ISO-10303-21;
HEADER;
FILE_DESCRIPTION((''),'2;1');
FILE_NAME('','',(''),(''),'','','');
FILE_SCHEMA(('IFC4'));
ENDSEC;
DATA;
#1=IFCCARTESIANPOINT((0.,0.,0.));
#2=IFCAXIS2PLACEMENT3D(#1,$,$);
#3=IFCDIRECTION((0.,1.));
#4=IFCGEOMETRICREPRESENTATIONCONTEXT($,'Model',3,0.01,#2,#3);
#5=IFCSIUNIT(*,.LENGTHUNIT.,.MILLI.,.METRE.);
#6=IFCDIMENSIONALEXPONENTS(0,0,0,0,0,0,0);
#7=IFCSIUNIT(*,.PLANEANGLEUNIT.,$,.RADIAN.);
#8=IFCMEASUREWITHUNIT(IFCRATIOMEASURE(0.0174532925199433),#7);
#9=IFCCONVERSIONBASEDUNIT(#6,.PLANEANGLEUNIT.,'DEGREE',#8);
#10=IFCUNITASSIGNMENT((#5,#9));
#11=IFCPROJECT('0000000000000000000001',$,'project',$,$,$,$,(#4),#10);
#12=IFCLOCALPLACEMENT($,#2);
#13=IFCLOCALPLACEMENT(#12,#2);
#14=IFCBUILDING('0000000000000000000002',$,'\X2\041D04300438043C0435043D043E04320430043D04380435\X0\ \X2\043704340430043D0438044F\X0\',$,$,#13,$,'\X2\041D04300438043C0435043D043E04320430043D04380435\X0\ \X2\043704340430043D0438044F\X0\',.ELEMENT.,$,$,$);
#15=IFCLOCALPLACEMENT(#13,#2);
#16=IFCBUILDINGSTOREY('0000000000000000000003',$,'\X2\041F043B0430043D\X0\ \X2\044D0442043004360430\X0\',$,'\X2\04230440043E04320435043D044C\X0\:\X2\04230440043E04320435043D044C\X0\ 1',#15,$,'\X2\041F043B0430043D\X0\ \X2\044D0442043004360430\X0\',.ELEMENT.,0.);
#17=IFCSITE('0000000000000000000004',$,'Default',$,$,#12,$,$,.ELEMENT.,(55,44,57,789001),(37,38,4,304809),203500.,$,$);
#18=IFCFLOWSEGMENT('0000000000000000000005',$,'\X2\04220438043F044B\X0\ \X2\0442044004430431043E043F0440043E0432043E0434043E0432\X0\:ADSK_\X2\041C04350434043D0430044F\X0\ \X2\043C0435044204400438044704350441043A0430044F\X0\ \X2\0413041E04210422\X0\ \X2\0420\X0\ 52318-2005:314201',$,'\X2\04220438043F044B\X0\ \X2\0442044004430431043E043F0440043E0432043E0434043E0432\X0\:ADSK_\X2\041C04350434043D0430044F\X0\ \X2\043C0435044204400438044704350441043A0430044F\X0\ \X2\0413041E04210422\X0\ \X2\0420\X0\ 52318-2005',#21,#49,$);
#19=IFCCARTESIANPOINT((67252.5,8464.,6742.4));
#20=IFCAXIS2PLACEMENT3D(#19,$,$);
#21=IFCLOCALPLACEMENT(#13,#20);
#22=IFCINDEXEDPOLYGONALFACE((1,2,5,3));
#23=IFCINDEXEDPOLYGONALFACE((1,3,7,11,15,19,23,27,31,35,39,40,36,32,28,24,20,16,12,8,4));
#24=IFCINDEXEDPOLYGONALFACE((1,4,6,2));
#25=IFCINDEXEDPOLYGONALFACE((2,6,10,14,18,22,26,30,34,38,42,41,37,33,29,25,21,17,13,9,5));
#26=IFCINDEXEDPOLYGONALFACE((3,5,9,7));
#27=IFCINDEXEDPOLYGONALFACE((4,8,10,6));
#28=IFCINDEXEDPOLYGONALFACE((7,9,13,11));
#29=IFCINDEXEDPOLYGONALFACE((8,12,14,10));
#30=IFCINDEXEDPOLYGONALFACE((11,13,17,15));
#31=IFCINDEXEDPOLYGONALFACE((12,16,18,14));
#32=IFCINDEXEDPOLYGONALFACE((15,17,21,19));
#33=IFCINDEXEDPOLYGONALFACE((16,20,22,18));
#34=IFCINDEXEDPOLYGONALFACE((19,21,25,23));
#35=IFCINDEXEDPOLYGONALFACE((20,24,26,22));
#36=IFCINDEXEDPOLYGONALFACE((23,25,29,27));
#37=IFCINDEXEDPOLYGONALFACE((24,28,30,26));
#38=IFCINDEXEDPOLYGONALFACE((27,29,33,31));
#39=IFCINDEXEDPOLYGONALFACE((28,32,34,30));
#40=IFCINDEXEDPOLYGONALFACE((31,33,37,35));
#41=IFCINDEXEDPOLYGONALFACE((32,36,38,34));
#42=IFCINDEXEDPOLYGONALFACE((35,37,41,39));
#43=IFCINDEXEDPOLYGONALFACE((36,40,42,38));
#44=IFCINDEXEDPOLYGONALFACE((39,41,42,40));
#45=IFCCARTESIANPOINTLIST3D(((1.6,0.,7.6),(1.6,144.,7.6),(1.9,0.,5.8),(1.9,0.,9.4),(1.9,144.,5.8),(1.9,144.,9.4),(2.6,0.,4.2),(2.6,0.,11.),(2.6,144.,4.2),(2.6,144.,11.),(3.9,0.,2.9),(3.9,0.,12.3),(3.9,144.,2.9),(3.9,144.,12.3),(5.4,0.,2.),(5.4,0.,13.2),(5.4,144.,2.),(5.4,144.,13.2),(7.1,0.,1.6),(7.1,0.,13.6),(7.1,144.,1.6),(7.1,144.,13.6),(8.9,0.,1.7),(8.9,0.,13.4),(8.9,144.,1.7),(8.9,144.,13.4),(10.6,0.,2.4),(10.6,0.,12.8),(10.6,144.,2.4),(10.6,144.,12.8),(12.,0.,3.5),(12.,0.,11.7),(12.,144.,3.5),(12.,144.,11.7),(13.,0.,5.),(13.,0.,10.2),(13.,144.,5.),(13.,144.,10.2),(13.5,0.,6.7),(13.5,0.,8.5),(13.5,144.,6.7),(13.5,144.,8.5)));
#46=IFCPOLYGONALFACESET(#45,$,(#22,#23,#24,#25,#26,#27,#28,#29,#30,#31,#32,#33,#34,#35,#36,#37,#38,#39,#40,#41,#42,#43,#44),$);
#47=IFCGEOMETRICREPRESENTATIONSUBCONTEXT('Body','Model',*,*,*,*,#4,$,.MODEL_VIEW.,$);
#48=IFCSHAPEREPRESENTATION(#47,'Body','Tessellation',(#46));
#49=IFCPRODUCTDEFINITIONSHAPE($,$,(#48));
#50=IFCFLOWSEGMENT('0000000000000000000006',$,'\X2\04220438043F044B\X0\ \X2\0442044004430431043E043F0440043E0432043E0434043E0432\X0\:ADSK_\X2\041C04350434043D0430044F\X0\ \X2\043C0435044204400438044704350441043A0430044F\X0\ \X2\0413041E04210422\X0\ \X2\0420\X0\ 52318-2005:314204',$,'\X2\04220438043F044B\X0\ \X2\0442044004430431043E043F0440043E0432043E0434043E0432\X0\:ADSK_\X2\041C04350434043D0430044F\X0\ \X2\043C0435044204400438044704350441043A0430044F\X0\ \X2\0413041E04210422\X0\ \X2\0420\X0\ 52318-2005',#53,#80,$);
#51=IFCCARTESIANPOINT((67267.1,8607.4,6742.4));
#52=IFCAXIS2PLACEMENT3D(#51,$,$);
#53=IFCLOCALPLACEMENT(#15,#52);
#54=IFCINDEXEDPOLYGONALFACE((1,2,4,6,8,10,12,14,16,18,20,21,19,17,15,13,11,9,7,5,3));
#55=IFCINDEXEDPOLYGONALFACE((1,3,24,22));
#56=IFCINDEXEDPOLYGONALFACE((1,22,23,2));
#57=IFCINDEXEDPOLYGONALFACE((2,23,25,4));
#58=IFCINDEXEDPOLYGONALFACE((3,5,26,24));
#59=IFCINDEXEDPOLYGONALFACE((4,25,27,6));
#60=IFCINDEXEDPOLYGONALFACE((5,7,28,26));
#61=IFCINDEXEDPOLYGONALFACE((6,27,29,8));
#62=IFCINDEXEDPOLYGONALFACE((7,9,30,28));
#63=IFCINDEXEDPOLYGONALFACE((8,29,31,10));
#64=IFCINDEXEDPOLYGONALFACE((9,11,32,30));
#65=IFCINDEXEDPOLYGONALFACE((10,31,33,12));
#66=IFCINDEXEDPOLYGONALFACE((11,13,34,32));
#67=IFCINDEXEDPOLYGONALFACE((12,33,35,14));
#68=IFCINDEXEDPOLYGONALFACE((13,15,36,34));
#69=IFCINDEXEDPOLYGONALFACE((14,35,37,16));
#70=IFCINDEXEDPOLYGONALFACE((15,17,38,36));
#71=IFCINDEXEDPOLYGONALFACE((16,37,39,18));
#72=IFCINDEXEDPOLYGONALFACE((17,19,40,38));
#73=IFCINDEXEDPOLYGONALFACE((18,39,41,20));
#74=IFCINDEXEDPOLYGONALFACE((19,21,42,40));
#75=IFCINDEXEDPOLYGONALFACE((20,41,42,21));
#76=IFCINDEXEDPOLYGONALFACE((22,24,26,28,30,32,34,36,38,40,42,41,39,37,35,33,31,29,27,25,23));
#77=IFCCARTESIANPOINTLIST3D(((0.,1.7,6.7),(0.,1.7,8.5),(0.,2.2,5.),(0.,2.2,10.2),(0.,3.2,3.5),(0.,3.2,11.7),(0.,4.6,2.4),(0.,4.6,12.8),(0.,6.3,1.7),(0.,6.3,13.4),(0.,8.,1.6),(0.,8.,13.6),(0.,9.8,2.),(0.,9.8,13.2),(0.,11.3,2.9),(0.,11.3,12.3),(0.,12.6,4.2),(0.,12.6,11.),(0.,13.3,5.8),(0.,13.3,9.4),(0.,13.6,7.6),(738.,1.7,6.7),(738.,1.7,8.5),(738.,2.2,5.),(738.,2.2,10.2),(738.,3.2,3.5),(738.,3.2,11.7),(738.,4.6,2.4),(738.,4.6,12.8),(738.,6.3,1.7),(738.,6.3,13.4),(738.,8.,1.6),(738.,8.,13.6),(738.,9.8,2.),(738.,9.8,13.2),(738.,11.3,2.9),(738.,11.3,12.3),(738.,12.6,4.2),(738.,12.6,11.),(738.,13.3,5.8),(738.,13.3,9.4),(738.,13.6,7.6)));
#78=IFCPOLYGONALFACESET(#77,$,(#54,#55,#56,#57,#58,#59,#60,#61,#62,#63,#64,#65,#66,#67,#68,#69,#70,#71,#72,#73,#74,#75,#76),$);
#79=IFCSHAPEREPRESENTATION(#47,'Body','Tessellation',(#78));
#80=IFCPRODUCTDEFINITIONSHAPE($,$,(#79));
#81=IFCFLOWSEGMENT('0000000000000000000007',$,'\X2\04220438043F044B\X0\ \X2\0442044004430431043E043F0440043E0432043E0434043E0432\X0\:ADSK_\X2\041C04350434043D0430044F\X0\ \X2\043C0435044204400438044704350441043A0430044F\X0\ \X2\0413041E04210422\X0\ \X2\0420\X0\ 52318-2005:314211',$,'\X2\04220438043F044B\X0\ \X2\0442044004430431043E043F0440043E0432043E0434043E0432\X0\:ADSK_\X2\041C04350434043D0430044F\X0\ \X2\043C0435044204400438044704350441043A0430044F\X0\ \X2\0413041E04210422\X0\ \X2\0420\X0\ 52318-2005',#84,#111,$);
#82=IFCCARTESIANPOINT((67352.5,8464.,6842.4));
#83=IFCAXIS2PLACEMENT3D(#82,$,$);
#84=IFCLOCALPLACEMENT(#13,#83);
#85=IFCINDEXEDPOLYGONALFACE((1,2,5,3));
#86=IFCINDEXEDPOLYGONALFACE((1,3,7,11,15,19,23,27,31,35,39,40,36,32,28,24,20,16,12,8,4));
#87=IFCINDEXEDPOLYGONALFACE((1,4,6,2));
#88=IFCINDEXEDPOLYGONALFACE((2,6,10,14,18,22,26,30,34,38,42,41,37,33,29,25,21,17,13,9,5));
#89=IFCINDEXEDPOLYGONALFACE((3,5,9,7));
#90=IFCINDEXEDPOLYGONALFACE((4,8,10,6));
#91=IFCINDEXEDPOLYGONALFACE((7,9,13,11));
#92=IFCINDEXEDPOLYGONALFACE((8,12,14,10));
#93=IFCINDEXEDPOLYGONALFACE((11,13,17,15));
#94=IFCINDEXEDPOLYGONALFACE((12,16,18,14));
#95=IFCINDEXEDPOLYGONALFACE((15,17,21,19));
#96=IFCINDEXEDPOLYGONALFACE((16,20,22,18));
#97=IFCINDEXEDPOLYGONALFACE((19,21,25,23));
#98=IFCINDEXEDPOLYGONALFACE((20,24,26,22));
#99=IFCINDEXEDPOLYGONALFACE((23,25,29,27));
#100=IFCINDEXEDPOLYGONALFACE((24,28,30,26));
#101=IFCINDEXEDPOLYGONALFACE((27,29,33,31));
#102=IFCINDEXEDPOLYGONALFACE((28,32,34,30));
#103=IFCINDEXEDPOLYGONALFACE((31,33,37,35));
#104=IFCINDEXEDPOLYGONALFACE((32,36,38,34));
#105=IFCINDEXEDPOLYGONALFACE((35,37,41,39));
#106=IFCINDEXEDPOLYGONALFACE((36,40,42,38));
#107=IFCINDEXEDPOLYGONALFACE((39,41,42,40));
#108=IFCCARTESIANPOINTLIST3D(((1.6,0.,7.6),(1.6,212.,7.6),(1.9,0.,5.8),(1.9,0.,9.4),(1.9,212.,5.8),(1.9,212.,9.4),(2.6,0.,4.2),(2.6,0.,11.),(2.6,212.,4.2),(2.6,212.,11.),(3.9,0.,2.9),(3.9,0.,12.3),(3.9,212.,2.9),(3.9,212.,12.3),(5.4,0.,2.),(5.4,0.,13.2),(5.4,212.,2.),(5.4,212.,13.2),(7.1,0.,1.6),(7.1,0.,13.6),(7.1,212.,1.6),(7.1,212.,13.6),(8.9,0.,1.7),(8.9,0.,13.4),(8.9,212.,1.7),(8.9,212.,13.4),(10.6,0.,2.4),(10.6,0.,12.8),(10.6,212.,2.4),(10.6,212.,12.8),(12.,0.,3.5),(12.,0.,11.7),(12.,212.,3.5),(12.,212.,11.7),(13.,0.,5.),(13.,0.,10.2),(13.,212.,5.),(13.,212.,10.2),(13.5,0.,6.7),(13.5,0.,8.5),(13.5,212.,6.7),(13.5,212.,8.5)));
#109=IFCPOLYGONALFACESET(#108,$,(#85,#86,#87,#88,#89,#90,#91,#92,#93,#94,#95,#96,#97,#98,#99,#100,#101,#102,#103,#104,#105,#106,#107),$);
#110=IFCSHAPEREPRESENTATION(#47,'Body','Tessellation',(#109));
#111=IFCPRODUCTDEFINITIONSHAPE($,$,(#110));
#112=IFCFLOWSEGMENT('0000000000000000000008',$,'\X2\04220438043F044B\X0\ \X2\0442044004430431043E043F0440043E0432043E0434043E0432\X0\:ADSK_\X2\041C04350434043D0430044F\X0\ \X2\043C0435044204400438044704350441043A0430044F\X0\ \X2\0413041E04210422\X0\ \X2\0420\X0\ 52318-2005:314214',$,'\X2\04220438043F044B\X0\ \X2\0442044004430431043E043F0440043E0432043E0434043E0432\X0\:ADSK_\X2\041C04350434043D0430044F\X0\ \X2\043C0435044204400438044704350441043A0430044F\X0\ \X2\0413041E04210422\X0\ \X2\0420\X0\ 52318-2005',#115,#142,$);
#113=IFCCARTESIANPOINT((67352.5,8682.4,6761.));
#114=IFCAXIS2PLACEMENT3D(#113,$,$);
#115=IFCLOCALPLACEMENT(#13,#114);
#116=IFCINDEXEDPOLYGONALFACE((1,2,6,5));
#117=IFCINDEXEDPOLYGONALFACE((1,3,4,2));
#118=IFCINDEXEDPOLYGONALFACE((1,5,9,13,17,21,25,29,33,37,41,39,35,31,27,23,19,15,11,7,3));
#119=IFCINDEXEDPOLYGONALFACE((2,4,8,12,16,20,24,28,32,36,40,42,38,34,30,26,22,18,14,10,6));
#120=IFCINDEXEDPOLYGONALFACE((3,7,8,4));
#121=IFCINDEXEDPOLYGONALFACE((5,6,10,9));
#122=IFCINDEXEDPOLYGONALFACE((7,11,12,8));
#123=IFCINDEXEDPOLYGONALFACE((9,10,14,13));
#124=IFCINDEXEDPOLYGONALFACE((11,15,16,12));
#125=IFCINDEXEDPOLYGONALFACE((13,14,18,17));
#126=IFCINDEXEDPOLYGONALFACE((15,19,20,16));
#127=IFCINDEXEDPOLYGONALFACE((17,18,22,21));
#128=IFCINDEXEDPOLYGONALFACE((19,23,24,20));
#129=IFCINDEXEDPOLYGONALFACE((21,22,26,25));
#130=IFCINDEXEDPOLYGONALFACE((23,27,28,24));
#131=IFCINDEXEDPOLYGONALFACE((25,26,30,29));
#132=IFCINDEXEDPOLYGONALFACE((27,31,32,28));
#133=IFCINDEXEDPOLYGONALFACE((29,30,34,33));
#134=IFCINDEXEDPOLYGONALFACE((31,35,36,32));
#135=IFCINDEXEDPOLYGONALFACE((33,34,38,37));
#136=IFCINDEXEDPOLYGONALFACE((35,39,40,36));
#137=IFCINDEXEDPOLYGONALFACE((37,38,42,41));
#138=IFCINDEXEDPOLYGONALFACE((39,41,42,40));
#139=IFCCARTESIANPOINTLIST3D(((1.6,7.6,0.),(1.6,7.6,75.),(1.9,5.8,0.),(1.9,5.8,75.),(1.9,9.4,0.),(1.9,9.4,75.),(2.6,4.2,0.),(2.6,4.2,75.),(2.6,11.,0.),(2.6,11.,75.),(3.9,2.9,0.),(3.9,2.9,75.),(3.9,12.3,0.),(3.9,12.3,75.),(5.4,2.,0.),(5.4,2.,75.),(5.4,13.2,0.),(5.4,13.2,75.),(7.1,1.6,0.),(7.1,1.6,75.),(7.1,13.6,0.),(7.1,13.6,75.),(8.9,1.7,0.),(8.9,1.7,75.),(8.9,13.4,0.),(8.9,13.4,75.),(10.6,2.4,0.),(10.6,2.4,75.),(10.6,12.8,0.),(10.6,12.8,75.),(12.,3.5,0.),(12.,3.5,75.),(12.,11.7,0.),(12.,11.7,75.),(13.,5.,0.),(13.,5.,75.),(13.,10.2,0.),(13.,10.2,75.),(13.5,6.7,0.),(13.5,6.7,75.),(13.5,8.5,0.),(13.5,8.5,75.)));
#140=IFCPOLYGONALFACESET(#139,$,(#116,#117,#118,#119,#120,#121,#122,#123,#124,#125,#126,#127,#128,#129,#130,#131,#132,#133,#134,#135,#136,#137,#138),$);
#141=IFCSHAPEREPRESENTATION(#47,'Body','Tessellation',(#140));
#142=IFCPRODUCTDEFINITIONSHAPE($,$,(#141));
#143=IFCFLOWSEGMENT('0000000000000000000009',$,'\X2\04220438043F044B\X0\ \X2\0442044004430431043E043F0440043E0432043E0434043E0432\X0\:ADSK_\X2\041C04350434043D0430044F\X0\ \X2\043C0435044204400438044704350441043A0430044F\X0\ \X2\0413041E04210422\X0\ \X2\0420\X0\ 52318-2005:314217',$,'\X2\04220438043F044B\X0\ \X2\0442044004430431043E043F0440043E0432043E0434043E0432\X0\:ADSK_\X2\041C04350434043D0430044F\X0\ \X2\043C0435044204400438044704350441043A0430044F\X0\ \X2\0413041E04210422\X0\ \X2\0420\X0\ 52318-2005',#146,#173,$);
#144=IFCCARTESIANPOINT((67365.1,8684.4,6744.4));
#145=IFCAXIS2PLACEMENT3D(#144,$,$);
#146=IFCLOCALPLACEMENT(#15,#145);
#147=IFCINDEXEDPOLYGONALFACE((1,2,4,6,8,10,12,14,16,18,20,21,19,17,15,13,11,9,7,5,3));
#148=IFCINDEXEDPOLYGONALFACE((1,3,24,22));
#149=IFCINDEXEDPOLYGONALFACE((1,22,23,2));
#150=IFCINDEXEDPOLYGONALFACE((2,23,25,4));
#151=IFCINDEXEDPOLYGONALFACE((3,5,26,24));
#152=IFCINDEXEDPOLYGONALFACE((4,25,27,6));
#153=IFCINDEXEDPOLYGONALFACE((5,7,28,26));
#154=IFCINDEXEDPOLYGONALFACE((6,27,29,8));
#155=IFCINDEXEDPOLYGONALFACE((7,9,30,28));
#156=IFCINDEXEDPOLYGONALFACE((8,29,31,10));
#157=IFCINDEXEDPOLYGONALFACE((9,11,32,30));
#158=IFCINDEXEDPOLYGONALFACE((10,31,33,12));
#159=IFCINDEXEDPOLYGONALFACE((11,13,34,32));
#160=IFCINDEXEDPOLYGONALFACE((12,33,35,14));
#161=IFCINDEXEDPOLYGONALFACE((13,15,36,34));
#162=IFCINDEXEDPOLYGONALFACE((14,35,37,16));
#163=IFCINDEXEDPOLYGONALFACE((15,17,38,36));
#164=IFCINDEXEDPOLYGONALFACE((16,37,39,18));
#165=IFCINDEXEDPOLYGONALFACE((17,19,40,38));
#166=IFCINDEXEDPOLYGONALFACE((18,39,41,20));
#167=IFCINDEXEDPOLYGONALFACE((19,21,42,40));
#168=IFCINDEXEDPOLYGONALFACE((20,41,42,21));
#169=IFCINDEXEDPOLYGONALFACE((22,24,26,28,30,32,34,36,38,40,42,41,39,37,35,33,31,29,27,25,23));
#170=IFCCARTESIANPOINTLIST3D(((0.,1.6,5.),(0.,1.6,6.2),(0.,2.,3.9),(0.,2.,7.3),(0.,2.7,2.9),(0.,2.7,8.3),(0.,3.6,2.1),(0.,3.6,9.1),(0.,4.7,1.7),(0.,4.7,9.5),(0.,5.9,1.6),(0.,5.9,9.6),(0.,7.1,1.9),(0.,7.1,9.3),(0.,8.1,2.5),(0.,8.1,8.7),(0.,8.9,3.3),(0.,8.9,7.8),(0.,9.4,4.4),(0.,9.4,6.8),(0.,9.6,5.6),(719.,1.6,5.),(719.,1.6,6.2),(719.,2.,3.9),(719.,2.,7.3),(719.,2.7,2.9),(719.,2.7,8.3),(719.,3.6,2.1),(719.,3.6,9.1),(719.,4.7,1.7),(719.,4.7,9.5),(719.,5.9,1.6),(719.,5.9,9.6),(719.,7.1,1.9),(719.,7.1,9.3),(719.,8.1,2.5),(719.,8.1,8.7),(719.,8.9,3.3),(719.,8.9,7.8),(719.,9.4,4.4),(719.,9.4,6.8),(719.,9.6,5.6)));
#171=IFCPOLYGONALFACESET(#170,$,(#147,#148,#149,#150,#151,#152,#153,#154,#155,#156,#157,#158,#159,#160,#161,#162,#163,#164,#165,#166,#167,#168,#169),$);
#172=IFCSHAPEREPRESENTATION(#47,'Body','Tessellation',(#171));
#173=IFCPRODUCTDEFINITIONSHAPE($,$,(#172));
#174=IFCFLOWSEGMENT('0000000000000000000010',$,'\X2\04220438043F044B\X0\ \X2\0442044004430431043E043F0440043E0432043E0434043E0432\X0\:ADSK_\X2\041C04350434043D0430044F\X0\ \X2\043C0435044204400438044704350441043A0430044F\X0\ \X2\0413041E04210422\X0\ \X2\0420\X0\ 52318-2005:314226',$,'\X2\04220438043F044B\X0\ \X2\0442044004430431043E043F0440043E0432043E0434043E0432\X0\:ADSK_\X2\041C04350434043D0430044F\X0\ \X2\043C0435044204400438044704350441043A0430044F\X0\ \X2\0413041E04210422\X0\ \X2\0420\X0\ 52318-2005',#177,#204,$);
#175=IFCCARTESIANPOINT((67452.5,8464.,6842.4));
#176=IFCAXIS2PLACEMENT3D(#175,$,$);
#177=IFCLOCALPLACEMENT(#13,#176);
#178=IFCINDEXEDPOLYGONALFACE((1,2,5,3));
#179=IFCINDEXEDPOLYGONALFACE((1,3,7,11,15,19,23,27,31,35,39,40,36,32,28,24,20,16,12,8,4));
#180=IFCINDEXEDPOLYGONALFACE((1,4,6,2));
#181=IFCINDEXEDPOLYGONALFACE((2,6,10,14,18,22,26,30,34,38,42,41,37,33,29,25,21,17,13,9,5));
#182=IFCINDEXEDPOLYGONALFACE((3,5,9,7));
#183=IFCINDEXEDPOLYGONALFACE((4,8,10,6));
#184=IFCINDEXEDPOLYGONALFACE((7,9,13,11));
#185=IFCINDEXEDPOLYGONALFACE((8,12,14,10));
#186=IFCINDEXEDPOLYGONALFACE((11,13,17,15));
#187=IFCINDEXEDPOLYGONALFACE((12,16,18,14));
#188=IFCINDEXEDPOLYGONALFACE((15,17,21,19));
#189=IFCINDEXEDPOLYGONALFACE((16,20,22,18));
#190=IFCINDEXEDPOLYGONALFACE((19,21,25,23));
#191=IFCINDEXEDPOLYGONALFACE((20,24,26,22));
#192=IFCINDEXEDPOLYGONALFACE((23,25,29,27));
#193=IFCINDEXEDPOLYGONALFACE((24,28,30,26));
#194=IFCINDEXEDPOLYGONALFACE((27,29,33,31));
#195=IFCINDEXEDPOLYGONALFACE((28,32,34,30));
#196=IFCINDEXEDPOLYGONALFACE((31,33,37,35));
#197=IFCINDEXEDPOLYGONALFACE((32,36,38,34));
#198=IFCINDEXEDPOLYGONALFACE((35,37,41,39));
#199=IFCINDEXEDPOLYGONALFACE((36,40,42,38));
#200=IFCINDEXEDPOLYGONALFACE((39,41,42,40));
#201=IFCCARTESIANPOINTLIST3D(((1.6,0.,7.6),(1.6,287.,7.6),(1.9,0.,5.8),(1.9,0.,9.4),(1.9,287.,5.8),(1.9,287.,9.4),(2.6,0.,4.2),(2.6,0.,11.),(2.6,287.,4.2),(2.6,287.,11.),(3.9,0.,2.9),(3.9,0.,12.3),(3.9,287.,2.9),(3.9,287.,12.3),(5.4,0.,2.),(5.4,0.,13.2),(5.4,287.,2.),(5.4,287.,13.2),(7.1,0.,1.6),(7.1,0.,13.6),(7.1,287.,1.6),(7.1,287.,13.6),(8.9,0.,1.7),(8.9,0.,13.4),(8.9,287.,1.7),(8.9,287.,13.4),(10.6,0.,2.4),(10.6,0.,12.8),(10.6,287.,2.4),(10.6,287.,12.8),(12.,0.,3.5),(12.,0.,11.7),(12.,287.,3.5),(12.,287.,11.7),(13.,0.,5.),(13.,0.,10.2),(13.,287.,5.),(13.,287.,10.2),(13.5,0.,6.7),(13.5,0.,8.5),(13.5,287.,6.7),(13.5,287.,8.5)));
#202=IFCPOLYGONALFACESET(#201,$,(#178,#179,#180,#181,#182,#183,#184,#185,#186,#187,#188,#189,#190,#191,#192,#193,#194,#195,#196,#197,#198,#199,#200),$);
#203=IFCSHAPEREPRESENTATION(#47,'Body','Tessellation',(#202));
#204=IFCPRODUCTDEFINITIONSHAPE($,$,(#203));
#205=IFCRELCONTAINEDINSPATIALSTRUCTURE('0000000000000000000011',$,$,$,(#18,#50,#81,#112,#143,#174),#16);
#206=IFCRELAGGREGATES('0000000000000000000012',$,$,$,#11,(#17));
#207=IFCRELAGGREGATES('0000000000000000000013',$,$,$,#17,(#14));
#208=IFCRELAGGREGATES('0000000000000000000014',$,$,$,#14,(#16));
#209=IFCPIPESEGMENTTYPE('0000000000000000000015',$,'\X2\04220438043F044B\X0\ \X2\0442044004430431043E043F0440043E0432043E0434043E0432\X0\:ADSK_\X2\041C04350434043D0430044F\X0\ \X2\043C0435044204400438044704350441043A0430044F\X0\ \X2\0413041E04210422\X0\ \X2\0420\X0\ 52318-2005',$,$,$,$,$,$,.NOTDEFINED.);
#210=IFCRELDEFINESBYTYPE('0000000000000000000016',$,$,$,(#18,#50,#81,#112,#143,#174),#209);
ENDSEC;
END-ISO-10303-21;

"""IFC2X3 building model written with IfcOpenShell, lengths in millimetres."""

from ifc_helpers import new_model, entity, si_unit, converted_unit, direction, frame, frame_2d, origin, origin_2d_with_axis, place, context, subcontext, project, spatial, circle, extrude, type_object, element, save


model = new_model("IFC2X3")

# Units and contexts
model_context = context("Model", 3, precision=0.01, world=origin(), true_north=direction((0.0, 1.0)))
body_context = subcontext(model_context, "Body", "Model", "MODEL_VIEW")
ifc_project = project(units=[si_unit("LENGTHUNIT", "METRE", prefix="MILLI"), converted_unit("PLANEANGLEUNIT", "DEGREE", entity("IfcRatioMeasure", 0.0174532925199433), si_unit("PLANEANGLEUNIT", "RADIAN"), dimensions=[0, 0, 0, 0, 0, 0, 0])], contexts=[model_context])

# Site, building, storey
site_placement = place(None, frame((0.0, 0.0, 0.0)))
site = spatial("IfcSite", under=ifc_project, at=site_placement, Name="Default", CompositionType="ELEMENT", RefLatitude=(55, 44, 57, 789001), RefLongitude=(37, 38, 4, 304809), RefElevation=203500.0)
building_placement = place(site_placement, origin())
building = spatial("IfcBuilding", under=site, at=building_placement, Name="Наименование здания", LongName="Наименование здания", CompositionType="ELEMENT")
storey_placement = place(building_placement, origin())
storey = spatial("IfcBuildingStorey", under=building, at=storey_placement, Name="План этажа", ObjectType="Уровень:Уровень 1", LongName="План этажа", CompositionType="ELEMENT", Elevation=0.0)

# Flow segments
pipe_segment_type = type_object("IfcPipeSegmentType", Name="Типы трубопроводов:ADSK_Медная метрическая ГОСТ Р 52318-2005", PredefinedType="NOTDEFINED")
flow_segment_1_placement = place(building_placement, frame((67252.5, 8464.0, 6742.4)))
element("IfcFlowSegment", 1, at=flow_segment_1_placement, inside=storey, type_object=pipe_segment_type, Name="Типы трубопроводов:ADSK_Медная метрическая ГОСТ Р 52318-2005:314201", ObjectType="Типы трубопроводов:ADSK_Медная метрическая ГОСТ Р 52318-2005", context=body_context, shape_type="SweptSolid", body=[
    extrude(circle(Radius=6.0, at=frame_2d((0.0, 0.0), x_axis=(1.0, 0.0))), frame((7.6, 0.0, 7.6), z_axis=(0.0, 1.0, 0.0), x_axis=(-1.0, 0.0, 0.0)), (0.0, 0.0, 1.0), 144.0),
])
flow_segment_2_placement = place(storey_placement, frame((67267.1, 8607.4, 6742.4)))
element("IfcFlowSegment", 2, at=flow_segment_2_placement, inside=storey, type_object=pipe_segment_type, Name="Типы трубопроводов:ADSK_Медная метрическая ГОСТ Р 52318-2005:314204", ObjectType="Типы трубопроводов:ADSK_Медная метрическая ГОСТ Р 52318-2005", context=body_context, shape_type="SweptSolid", body=[
    extrude(circle(Radius=6.0, at=frame_2d((0.0, 0.0), x_axis=(1.0, 0.0))), frame((0.0, 7.6, 7.6), z_axis=(1.0, 0.0, 0.0), x_axis=(0.0, 1.0, 0.0)), (0.0, 0.0, 1.0), 738.0),
])
flow_segment_3_placement = place(building_placement, frame((67352.5, 8464.0, 6842.4)))
element("IfcFlowSegment", 3, at=flow_segment_3_placement, inside=storey, type_object=pipe_segment_type, Name="Типы трубопроводов:ADSK_Медная метрическая ГОСТ Р 52318-2005:314211", ObjectType="Типы трубопроводов:ADSK_Медная метрическая ГОСТ Р 52318-2005", context=body_context, shape_type="SweptSolid", body=[
    extrude(circle(Radius=6.0, at=origin_2d_with_axis()), frame((7.6, 0.0, 7.6), z_axis=(0.0, 1.0, 0.0), x_axis=(-1.0, 0.0, 0.0)), (0.0, 0.0, 1.0), 212.0),
])
flow_segment_4_placement = place(building_placement, frame((67352.5, 8682.4, 6761.0)))
element("IfcFlowSegment", 4, at=flow_segment_4_placement, inside=storey, type_object=pipe_segment_type, Name="Типы трубопроводов:ADSK_Медная метрическая ГОСТ Р 52318-2005:314214", ObjectType="Типы трубопроводов:ADSK_Медная метрическая ГОСТ Р 52318-2005", context=body_context, shape_type="SweptSolid", body=[
    extrude(circle(Radius=6.0, at=origin_2d_with_axis()), frame((7.6, 7.6, 0.0), z_axis=(0.0, 0.0, 1.0), x_axis=(-1.0, 0.0, 0.0)), (0.0, 0.0, 1.0), 75.0),
])
flow_segment_5_placement = place(storey_placement, frame((67365.1, 8684.4, 6744.4)))
element("IfcFlowSegment", 5, at=flow_segment_5_placement, inside=storey, type_object=pipe_segment_type, Name="Типы трубопроводов:ADSK_Медная метрическая ГОСТ Р 52318-2005:314217", ObjectType="Типы трубопроводов:ADSK_Медная метрическая ГОСТ Р 52318-2005", context=body_context, shape_type="SweptSolid", body=[
    extrude(circle(Radius=4.0, at=origin_2d_with_axis()), frame((0.0, 5.6, 5.6), z_axis=(1.0, 0.0, 0.0), x_axis=(0.0, 1.0, 0.0)), (0.0, 0.0, 1.0), 719.0),
])
flow_segment_6_placement = place(building_placement, frame((67452.5, 8464.0, 6842.4)))
element("IfcFlowSegment", 6, at=flow_segment_6_placement, inside=storey, type_object=pipe_segment_type, Name="Типы трубопроводов:ADSK_Медная метрическая ГОСТ Р 52318-2005:314226", ObjectType="Типы трубопроводов:ADSK_Медная метрическая ГОСТ Р 52318-2005", context=body_context, shape_type="SweptSolid", body=[
    extrude(circle(Radius=6.0, at=origin_2d_with_axis()), frame((7.6, 0.0, 7.6), z_axis=(0.0, 1.0, 0.0), x_axis=(-1.0, 0.0, 0.0)), (0.0, 0.0, 1.0), 287.0),
])

save(model, "model.ifc")
